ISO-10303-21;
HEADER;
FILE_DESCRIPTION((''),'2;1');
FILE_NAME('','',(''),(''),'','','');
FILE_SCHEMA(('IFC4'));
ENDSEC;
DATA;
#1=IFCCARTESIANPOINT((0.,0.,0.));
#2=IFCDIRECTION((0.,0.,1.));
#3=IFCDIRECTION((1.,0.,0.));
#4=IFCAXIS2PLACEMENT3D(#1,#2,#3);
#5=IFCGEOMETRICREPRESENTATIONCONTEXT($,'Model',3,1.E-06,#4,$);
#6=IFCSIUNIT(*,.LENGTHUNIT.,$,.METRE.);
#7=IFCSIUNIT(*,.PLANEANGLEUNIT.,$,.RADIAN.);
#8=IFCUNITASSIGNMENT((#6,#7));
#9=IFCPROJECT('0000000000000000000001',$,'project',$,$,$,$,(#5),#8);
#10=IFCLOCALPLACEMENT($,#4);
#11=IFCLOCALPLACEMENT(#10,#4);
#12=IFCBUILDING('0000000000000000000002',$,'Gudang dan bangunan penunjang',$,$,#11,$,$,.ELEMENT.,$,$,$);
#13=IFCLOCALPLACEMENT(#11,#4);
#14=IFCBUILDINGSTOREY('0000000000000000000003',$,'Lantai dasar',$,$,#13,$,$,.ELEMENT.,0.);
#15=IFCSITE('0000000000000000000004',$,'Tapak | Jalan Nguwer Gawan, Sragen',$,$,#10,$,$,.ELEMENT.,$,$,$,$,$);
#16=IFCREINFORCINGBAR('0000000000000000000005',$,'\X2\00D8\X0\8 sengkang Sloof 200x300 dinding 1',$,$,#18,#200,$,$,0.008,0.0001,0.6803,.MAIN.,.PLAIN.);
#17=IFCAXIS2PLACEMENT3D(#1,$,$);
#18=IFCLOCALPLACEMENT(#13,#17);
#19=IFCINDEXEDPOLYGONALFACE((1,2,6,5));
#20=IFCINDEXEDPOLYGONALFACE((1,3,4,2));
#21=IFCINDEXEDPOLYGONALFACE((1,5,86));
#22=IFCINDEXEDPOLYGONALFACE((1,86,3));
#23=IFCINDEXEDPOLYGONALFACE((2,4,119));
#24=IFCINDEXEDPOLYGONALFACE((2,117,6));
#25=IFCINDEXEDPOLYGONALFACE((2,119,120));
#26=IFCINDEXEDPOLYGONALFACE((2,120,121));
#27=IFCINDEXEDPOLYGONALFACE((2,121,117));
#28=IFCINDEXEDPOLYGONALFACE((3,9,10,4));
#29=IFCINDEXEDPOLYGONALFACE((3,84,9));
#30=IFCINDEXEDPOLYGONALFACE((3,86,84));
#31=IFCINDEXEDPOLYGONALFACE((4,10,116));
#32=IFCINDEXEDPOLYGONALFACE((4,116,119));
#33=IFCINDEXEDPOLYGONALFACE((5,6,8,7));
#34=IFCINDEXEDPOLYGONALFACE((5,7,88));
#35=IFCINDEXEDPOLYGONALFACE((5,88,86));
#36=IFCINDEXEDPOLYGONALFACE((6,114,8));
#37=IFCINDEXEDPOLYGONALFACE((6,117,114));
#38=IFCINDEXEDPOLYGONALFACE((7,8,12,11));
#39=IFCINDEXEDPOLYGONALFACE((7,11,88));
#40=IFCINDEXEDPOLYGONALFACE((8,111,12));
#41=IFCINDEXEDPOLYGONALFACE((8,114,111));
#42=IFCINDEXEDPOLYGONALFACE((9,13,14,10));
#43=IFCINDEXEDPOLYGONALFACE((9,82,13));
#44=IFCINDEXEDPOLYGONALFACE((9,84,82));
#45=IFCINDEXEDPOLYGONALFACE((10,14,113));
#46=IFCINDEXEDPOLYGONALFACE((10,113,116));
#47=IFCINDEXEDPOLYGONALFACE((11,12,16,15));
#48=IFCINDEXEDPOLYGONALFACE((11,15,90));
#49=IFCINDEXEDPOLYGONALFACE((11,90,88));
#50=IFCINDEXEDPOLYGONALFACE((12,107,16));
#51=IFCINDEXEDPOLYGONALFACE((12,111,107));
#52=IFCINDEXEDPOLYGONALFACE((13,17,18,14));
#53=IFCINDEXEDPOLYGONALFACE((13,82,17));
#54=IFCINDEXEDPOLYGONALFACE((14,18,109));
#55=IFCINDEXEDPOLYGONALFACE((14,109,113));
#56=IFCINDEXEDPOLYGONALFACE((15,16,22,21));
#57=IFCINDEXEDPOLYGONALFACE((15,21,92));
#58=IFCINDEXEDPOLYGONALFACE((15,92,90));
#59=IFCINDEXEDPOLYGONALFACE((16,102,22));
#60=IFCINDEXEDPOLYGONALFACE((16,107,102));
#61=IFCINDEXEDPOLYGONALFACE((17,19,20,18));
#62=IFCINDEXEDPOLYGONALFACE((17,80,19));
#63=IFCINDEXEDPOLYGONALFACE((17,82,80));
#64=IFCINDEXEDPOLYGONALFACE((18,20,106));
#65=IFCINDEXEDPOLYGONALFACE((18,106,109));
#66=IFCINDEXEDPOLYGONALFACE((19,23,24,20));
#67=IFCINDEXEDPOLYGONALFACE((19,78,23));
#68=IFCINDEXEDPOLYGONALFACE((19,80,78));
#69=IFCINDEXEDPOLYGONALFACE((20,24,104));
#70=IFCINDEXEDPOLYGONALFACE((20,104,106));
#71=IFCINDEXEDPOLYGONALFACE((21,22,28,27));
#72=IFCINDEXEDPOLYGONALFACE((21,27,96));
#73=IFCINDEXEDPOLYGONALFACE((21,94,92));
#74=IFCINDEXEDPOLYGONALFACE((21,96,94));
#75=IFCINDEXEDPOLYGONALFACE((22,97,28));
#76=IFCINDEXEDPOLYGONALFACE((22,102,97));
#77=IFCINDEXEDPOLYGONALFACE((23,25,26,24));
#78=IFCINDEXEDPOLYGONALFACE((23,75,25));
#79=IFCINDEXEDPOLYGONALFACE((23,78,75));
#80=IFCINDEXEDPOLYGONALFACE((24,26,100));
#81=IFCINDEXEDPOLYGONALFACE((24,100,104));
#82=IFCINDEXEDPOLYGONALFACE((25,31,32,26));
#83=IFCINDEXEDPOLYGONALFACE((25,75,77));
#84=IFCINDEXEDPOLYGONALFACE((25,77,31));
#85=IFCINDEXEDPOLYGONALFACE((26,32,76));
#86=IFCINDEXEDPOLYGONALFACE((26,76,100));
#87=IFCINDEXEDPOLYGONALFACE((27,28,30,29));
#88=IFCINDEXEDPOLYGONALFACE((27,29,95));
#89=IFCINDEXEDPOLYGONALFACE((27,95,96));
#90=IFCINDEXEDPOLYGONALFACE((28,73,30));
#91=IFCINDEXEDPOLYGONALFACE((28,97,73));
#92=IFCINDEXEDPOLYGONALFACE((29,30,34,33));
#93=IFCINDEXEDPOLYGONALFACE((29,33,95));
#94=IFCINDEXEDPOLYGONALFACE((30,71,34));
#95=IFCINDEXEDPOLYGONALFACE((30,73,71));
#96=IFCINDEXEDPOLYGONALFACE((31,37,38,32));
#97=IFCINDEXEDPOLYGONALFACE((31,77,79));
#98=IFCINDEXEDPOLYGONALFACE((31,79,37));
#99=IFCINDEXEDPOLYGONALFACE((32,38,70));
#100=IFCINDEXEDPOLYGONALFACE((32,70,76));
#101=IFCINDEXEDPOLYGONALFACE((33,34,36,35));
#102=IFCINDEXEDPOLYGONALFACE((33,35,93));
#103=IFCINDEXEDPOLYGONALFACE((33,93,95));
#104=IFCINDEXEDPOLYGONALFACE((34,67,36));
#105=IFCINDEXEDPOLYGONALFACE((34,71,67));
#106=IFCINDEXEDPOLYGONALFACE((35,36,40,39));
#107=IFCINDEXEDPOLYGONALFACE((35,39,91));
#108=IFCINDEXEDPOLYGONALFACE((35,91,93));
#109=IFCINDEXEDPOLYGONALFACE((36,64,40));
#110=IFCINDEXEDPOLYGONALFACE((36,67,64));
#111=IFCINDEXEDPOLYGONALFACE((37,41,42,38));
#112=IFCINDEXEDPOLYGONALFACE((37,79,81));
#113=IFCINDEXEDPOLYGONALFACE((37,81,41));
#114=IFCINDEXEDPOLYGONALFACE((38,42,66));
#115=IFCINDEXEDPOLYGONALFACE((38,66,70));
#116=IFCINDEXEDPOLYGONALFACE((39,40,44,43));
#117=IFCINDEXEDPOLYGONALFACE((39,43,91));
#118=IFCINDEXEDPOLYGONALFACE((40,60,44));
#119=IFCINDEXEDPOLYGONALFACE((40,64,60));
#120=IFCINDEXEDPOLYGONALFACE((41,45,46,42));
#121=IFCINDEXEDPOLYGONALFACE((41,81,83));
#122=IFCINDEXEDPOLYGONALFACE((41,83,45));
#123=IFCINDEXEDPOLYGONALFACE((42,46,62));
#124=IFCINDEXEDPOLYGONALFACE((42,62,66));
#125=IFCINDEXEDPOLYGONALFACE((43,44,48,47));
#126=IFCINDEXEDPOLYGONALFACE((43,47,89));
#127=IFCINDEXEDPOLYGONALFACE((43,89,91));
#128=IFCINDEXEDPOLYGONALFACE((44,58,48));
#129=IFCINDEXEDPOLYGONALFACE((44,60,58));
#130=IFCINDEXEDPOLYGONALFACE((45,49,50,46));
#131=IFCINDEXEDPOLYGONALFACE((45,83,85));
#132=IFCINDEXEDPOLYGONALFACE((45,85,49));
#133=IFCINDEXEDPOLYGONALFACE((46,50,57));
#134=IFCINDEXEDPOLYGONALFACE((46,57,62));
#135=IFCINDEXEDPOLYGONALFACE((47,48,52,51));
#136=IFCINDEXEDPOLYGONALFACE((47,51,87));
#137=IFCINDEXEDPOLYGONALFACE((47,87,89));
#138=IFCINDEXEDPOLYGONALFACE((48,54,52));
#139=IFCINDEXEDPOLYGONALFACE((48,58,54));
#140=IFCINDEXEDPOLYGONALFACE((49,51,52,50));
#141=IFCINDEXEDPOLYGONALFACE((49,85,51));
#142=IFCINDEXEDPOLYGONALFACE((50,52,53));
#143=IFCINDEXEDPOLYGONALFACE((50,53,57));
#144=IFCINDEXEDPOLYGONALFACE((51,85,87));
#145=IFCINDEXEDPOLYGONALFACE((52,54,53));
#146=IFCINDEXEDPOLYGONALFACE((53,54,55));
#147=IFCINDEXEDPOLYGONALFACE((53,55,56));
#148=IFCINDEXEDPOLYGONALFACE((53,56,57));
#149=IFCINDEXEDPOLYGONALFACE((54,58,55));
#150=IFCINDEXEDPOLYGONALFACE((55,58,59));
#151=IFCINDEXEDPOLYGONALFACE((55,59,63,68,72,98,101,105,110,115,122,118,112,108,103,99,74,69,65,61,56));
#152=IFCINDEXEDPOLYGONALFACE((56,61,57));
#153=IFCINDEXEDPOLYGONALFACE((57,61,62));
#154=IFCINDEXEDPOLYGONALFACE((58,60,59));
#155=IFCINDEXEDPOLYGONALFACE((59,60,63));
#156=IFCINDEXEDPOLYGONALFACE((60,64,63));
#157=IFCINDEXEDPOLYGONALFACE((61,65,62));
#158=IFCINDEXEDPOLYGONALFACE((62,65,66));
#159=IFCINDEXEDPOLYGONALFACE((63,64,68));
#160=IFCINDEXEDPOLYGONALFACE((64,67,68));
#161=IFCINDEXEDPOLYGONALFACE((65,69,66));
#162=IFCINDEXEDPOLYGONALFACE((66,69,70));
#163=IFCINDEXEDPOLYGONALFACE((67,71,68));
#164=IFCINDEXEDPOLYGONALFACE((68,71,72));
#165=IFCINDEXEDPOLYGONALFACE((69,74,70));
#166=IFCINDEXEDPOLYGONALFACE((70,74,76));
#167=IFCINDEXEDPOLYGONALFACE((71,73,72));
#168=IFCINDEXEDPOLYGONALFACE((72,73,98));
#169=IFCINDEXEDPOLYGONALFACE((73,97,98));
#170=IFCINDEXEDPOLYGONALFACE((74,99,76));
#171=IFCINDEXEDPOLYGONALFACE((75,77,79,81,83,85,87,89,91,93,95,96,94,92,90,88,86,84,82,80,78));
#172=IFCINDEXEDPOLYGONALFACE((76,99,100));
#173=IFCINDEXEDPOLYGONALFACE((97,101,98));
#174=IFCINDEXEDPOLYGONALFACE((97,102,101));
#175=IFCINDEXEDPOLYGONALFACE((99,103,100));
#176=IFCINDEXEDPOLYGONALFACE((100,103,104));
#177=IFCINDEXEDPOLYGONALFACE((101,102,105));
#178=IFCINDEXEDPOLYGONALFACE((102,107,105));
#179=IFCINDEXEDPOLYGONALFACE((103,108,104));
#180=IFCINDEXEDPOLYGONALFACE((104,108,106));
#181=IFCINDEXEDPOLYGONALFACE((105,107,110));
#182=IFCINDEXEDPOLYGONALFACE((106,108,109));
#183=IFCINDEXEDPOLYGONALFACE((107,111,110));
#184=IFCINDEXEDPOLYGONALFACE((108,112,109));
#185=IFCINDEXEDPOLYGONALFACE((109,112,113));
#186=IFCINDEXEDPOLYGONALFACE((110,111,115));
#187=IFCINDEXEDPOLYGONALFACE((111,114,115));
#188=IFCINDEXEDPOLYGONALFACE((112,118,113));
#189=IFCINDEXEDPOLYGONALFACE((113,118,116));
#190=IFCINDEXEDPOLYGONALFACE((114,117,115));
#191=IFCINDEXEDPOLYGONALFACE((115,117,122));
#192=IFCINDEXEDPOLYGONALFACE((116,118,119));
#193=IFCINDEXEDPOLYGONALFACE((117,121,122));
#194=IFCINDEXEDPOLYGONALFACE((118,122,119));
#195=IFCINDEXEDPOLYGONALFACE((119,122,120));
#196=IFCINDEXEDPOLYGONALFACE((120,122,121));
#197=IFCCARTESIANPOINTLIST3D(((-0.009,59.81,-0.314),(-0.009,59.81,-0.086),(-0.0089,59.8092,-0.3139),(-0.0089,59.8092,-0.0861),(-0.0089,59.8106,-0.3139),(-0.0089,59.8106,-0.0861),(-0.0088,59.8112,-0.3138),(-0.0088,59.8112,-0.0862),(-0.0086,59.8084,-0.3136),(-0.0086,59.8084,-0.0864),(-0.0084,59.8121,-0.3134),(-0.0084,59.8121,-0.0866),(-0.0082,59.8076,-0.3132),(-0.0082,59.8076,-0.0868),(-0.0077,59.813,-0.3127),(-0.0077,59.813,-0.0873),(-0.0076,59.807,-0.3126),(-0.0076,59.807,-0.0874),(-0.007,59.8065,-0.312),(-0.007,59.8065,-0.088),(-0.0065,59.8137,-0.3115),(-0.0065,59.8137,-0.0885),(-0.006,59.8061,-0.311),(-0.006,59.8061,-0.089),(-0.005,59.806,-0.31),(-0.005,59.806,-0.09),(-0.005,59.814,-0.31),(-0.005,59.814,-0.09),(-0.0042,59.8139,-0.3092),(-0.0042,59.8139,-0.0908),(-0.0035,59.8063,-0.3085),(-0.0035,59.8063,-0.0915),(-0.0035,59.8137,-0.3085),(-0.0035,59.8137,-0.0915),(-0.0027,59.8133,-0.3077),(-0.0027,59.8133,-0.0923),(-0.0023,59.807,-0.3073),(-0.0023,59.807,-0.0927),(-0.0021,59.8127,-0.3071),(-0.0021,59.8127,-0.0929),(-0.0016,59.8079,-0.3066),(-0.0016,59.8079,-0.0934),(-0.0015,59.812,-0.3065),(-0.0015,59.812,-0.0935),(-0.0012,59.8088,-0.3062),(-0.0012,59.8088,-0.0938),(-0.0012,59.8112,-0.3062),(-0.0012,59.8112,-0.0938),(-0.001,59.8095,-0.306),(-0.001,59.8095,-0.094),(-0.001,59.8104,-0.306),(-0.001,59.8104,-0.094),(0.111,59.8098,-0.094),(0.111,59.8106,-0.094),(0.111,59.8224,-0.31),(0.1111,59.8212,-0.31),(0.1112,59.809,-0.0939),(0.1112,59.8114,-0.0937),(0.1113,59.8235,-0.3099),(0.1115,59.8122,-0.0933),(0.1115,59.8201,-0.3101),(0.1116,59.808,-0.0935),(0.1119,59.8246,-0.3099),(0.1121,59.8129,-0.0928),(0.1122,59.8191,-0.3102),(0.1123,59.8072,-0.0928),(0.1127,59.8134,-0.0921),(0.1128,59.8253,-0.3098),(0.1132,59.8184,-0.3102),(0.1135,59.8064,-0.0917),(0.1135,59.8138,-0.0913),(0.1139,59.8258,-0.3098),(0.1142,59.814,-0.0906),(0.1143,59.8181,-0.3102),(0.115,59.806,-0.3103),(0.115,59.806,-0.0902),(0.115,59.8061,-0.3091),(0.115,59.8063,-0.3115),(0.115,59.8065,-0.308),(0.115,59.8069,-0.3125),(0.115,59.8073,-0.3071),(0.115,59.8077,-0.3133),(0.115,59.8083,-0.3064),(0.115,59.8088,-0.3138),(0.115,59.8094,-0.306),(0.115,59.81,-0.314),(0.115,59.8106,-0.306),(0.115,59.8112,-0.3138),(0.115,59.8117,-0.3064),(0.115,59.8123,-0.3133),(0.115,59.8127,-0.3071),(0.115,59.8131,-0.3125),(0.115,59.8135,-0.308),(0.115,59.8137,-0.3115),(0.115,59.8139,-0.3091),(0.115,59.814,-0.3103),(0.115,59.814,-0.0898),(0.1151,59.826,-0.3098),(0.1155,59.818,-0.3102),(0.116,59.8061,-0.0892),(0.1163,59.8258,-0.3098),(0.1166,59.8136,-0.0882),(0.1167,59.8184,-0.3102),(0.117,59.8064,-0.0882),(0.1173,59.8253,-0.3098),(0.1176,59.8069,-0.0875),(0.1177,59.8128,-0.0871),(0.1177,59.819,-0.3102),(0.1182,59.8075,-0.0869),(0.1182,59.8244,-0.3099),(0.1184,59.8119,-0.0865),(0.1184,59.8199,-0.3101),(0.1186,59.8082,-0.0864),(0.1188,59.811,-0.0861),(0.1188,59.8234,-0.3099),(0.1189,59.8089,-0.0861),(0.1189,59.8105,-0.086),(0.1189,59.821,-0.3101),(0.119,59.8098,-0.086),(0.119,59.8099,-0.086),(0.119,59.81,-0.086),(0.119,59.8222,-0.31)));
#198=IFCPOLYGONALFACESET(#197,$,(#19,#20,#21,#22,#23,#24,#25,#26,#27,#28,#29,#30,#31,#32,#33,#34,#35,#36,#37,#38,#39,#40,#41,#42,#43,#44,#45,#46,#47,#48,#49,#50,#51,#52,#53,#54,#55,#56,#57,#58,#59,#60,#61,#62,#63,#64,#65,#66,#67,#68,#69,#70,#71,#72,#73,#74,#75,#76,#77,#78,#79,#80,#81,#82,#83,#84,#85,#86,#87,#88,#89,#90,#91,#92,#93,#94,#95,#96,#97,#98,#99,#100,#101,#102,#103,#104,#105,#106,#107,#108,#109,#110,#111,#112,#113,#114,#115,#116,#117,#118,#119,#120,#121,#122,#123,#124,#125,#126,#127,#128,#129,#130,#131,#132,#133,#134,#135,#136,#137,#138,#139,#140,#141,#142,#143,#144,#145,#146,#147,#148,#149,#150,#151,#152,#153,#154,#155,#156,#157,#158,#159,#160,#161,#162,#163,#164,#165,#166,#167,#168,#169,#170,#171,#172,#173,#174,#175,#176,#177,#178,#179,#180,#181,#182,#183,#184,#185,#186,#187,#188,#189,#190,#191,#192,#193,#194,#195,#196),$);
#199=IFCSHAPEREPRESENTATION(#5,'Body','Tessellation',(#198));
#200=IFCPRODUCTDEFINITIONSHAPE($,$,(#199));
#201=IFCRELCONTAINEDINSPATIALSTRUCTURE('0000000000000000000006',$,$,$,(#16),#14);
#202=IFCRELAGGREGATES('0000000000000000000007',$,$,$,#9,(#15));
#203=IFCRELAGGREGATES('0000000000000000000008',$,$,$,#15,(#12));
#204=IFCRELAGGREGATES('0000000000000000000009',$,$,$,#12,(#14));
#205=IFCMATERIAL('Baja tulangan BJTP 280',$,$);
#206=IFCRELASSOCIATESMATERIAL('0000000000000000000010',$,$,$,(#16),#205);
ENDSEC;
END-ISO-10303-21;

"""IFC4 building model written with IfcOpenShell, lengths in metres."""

from ifc_helpers import new_model, entity, si_unit, origin_with_axes, place, context, project, spatial, material, element, save


model = new_model("IFC4")

# Units and contexts
model_context = context("Model", 3, precision=1e-06, world=origin_with_axes())
ifc_project = project(units=[si_unit("LENGTHUNIT", "METRE"), si_unit("PLANEANGLEUNIT", "RADIAN")], contexts=[model_context])

# Site, building, storey
site_placement = place(None, origin_with_axes())
site = spatial("IfcSite", under=ifc_project, at=site_placement, Name="Tapak | Jalan Nguwer Gawan, Sragen", CompositionType="ELEMENT")
building_placement = place(site_placement, origin_with_axes())
building = spatial("IfcBuilding", under=site, at=building_placement, Name="Gudang dan bangunan penunjang", CompositionType="ELEMENT")
storey_placement = place(building_placement, origin_with_axes())
storey = spatial("IfcBuildingStorey", under=building, at=storey_placement, Name="Lantai dasar", CompositionType="ELEMENT", Elevation=0.0)

# Shared definitions
placement = place(None, origin_with_axes())

# Reinforcing bar
ifc_material_1 = material(Name="Baja tulangan BJTP 280")
element("IfcReinforcingBar", 1, at=placement, inside=storey, material=ifc_material_1, Name="Ø8 sengkang Sloof 200x300 dinding 1", BarLength=0.6803, BarSurface="PLAIN", CrossSectionArea=0.0001, NominalDiameter=0.008, PredefinedType="MAIN", context=model_context, shape_type="AdvancedSweptSolid", body=[
    entity("IfcSweptDiskSolid", entity("IfcPolyline", [entity("IfcCartesianPoint", [0.115, 59.81, -0.31]), entity("IfcCartesianPoint", [-0.005, 59.81, -0.31]), entity("IfcCartesianPoint", [-0.005, 59.81, -0.09]), entity("IfcCartesianPoint", [0.115, 59.81, -0.09]), entity("IfcCartesianPoint", [0.115, 59.822, -0.31])]), 0.004),
])

save(model, "model.ifc")
